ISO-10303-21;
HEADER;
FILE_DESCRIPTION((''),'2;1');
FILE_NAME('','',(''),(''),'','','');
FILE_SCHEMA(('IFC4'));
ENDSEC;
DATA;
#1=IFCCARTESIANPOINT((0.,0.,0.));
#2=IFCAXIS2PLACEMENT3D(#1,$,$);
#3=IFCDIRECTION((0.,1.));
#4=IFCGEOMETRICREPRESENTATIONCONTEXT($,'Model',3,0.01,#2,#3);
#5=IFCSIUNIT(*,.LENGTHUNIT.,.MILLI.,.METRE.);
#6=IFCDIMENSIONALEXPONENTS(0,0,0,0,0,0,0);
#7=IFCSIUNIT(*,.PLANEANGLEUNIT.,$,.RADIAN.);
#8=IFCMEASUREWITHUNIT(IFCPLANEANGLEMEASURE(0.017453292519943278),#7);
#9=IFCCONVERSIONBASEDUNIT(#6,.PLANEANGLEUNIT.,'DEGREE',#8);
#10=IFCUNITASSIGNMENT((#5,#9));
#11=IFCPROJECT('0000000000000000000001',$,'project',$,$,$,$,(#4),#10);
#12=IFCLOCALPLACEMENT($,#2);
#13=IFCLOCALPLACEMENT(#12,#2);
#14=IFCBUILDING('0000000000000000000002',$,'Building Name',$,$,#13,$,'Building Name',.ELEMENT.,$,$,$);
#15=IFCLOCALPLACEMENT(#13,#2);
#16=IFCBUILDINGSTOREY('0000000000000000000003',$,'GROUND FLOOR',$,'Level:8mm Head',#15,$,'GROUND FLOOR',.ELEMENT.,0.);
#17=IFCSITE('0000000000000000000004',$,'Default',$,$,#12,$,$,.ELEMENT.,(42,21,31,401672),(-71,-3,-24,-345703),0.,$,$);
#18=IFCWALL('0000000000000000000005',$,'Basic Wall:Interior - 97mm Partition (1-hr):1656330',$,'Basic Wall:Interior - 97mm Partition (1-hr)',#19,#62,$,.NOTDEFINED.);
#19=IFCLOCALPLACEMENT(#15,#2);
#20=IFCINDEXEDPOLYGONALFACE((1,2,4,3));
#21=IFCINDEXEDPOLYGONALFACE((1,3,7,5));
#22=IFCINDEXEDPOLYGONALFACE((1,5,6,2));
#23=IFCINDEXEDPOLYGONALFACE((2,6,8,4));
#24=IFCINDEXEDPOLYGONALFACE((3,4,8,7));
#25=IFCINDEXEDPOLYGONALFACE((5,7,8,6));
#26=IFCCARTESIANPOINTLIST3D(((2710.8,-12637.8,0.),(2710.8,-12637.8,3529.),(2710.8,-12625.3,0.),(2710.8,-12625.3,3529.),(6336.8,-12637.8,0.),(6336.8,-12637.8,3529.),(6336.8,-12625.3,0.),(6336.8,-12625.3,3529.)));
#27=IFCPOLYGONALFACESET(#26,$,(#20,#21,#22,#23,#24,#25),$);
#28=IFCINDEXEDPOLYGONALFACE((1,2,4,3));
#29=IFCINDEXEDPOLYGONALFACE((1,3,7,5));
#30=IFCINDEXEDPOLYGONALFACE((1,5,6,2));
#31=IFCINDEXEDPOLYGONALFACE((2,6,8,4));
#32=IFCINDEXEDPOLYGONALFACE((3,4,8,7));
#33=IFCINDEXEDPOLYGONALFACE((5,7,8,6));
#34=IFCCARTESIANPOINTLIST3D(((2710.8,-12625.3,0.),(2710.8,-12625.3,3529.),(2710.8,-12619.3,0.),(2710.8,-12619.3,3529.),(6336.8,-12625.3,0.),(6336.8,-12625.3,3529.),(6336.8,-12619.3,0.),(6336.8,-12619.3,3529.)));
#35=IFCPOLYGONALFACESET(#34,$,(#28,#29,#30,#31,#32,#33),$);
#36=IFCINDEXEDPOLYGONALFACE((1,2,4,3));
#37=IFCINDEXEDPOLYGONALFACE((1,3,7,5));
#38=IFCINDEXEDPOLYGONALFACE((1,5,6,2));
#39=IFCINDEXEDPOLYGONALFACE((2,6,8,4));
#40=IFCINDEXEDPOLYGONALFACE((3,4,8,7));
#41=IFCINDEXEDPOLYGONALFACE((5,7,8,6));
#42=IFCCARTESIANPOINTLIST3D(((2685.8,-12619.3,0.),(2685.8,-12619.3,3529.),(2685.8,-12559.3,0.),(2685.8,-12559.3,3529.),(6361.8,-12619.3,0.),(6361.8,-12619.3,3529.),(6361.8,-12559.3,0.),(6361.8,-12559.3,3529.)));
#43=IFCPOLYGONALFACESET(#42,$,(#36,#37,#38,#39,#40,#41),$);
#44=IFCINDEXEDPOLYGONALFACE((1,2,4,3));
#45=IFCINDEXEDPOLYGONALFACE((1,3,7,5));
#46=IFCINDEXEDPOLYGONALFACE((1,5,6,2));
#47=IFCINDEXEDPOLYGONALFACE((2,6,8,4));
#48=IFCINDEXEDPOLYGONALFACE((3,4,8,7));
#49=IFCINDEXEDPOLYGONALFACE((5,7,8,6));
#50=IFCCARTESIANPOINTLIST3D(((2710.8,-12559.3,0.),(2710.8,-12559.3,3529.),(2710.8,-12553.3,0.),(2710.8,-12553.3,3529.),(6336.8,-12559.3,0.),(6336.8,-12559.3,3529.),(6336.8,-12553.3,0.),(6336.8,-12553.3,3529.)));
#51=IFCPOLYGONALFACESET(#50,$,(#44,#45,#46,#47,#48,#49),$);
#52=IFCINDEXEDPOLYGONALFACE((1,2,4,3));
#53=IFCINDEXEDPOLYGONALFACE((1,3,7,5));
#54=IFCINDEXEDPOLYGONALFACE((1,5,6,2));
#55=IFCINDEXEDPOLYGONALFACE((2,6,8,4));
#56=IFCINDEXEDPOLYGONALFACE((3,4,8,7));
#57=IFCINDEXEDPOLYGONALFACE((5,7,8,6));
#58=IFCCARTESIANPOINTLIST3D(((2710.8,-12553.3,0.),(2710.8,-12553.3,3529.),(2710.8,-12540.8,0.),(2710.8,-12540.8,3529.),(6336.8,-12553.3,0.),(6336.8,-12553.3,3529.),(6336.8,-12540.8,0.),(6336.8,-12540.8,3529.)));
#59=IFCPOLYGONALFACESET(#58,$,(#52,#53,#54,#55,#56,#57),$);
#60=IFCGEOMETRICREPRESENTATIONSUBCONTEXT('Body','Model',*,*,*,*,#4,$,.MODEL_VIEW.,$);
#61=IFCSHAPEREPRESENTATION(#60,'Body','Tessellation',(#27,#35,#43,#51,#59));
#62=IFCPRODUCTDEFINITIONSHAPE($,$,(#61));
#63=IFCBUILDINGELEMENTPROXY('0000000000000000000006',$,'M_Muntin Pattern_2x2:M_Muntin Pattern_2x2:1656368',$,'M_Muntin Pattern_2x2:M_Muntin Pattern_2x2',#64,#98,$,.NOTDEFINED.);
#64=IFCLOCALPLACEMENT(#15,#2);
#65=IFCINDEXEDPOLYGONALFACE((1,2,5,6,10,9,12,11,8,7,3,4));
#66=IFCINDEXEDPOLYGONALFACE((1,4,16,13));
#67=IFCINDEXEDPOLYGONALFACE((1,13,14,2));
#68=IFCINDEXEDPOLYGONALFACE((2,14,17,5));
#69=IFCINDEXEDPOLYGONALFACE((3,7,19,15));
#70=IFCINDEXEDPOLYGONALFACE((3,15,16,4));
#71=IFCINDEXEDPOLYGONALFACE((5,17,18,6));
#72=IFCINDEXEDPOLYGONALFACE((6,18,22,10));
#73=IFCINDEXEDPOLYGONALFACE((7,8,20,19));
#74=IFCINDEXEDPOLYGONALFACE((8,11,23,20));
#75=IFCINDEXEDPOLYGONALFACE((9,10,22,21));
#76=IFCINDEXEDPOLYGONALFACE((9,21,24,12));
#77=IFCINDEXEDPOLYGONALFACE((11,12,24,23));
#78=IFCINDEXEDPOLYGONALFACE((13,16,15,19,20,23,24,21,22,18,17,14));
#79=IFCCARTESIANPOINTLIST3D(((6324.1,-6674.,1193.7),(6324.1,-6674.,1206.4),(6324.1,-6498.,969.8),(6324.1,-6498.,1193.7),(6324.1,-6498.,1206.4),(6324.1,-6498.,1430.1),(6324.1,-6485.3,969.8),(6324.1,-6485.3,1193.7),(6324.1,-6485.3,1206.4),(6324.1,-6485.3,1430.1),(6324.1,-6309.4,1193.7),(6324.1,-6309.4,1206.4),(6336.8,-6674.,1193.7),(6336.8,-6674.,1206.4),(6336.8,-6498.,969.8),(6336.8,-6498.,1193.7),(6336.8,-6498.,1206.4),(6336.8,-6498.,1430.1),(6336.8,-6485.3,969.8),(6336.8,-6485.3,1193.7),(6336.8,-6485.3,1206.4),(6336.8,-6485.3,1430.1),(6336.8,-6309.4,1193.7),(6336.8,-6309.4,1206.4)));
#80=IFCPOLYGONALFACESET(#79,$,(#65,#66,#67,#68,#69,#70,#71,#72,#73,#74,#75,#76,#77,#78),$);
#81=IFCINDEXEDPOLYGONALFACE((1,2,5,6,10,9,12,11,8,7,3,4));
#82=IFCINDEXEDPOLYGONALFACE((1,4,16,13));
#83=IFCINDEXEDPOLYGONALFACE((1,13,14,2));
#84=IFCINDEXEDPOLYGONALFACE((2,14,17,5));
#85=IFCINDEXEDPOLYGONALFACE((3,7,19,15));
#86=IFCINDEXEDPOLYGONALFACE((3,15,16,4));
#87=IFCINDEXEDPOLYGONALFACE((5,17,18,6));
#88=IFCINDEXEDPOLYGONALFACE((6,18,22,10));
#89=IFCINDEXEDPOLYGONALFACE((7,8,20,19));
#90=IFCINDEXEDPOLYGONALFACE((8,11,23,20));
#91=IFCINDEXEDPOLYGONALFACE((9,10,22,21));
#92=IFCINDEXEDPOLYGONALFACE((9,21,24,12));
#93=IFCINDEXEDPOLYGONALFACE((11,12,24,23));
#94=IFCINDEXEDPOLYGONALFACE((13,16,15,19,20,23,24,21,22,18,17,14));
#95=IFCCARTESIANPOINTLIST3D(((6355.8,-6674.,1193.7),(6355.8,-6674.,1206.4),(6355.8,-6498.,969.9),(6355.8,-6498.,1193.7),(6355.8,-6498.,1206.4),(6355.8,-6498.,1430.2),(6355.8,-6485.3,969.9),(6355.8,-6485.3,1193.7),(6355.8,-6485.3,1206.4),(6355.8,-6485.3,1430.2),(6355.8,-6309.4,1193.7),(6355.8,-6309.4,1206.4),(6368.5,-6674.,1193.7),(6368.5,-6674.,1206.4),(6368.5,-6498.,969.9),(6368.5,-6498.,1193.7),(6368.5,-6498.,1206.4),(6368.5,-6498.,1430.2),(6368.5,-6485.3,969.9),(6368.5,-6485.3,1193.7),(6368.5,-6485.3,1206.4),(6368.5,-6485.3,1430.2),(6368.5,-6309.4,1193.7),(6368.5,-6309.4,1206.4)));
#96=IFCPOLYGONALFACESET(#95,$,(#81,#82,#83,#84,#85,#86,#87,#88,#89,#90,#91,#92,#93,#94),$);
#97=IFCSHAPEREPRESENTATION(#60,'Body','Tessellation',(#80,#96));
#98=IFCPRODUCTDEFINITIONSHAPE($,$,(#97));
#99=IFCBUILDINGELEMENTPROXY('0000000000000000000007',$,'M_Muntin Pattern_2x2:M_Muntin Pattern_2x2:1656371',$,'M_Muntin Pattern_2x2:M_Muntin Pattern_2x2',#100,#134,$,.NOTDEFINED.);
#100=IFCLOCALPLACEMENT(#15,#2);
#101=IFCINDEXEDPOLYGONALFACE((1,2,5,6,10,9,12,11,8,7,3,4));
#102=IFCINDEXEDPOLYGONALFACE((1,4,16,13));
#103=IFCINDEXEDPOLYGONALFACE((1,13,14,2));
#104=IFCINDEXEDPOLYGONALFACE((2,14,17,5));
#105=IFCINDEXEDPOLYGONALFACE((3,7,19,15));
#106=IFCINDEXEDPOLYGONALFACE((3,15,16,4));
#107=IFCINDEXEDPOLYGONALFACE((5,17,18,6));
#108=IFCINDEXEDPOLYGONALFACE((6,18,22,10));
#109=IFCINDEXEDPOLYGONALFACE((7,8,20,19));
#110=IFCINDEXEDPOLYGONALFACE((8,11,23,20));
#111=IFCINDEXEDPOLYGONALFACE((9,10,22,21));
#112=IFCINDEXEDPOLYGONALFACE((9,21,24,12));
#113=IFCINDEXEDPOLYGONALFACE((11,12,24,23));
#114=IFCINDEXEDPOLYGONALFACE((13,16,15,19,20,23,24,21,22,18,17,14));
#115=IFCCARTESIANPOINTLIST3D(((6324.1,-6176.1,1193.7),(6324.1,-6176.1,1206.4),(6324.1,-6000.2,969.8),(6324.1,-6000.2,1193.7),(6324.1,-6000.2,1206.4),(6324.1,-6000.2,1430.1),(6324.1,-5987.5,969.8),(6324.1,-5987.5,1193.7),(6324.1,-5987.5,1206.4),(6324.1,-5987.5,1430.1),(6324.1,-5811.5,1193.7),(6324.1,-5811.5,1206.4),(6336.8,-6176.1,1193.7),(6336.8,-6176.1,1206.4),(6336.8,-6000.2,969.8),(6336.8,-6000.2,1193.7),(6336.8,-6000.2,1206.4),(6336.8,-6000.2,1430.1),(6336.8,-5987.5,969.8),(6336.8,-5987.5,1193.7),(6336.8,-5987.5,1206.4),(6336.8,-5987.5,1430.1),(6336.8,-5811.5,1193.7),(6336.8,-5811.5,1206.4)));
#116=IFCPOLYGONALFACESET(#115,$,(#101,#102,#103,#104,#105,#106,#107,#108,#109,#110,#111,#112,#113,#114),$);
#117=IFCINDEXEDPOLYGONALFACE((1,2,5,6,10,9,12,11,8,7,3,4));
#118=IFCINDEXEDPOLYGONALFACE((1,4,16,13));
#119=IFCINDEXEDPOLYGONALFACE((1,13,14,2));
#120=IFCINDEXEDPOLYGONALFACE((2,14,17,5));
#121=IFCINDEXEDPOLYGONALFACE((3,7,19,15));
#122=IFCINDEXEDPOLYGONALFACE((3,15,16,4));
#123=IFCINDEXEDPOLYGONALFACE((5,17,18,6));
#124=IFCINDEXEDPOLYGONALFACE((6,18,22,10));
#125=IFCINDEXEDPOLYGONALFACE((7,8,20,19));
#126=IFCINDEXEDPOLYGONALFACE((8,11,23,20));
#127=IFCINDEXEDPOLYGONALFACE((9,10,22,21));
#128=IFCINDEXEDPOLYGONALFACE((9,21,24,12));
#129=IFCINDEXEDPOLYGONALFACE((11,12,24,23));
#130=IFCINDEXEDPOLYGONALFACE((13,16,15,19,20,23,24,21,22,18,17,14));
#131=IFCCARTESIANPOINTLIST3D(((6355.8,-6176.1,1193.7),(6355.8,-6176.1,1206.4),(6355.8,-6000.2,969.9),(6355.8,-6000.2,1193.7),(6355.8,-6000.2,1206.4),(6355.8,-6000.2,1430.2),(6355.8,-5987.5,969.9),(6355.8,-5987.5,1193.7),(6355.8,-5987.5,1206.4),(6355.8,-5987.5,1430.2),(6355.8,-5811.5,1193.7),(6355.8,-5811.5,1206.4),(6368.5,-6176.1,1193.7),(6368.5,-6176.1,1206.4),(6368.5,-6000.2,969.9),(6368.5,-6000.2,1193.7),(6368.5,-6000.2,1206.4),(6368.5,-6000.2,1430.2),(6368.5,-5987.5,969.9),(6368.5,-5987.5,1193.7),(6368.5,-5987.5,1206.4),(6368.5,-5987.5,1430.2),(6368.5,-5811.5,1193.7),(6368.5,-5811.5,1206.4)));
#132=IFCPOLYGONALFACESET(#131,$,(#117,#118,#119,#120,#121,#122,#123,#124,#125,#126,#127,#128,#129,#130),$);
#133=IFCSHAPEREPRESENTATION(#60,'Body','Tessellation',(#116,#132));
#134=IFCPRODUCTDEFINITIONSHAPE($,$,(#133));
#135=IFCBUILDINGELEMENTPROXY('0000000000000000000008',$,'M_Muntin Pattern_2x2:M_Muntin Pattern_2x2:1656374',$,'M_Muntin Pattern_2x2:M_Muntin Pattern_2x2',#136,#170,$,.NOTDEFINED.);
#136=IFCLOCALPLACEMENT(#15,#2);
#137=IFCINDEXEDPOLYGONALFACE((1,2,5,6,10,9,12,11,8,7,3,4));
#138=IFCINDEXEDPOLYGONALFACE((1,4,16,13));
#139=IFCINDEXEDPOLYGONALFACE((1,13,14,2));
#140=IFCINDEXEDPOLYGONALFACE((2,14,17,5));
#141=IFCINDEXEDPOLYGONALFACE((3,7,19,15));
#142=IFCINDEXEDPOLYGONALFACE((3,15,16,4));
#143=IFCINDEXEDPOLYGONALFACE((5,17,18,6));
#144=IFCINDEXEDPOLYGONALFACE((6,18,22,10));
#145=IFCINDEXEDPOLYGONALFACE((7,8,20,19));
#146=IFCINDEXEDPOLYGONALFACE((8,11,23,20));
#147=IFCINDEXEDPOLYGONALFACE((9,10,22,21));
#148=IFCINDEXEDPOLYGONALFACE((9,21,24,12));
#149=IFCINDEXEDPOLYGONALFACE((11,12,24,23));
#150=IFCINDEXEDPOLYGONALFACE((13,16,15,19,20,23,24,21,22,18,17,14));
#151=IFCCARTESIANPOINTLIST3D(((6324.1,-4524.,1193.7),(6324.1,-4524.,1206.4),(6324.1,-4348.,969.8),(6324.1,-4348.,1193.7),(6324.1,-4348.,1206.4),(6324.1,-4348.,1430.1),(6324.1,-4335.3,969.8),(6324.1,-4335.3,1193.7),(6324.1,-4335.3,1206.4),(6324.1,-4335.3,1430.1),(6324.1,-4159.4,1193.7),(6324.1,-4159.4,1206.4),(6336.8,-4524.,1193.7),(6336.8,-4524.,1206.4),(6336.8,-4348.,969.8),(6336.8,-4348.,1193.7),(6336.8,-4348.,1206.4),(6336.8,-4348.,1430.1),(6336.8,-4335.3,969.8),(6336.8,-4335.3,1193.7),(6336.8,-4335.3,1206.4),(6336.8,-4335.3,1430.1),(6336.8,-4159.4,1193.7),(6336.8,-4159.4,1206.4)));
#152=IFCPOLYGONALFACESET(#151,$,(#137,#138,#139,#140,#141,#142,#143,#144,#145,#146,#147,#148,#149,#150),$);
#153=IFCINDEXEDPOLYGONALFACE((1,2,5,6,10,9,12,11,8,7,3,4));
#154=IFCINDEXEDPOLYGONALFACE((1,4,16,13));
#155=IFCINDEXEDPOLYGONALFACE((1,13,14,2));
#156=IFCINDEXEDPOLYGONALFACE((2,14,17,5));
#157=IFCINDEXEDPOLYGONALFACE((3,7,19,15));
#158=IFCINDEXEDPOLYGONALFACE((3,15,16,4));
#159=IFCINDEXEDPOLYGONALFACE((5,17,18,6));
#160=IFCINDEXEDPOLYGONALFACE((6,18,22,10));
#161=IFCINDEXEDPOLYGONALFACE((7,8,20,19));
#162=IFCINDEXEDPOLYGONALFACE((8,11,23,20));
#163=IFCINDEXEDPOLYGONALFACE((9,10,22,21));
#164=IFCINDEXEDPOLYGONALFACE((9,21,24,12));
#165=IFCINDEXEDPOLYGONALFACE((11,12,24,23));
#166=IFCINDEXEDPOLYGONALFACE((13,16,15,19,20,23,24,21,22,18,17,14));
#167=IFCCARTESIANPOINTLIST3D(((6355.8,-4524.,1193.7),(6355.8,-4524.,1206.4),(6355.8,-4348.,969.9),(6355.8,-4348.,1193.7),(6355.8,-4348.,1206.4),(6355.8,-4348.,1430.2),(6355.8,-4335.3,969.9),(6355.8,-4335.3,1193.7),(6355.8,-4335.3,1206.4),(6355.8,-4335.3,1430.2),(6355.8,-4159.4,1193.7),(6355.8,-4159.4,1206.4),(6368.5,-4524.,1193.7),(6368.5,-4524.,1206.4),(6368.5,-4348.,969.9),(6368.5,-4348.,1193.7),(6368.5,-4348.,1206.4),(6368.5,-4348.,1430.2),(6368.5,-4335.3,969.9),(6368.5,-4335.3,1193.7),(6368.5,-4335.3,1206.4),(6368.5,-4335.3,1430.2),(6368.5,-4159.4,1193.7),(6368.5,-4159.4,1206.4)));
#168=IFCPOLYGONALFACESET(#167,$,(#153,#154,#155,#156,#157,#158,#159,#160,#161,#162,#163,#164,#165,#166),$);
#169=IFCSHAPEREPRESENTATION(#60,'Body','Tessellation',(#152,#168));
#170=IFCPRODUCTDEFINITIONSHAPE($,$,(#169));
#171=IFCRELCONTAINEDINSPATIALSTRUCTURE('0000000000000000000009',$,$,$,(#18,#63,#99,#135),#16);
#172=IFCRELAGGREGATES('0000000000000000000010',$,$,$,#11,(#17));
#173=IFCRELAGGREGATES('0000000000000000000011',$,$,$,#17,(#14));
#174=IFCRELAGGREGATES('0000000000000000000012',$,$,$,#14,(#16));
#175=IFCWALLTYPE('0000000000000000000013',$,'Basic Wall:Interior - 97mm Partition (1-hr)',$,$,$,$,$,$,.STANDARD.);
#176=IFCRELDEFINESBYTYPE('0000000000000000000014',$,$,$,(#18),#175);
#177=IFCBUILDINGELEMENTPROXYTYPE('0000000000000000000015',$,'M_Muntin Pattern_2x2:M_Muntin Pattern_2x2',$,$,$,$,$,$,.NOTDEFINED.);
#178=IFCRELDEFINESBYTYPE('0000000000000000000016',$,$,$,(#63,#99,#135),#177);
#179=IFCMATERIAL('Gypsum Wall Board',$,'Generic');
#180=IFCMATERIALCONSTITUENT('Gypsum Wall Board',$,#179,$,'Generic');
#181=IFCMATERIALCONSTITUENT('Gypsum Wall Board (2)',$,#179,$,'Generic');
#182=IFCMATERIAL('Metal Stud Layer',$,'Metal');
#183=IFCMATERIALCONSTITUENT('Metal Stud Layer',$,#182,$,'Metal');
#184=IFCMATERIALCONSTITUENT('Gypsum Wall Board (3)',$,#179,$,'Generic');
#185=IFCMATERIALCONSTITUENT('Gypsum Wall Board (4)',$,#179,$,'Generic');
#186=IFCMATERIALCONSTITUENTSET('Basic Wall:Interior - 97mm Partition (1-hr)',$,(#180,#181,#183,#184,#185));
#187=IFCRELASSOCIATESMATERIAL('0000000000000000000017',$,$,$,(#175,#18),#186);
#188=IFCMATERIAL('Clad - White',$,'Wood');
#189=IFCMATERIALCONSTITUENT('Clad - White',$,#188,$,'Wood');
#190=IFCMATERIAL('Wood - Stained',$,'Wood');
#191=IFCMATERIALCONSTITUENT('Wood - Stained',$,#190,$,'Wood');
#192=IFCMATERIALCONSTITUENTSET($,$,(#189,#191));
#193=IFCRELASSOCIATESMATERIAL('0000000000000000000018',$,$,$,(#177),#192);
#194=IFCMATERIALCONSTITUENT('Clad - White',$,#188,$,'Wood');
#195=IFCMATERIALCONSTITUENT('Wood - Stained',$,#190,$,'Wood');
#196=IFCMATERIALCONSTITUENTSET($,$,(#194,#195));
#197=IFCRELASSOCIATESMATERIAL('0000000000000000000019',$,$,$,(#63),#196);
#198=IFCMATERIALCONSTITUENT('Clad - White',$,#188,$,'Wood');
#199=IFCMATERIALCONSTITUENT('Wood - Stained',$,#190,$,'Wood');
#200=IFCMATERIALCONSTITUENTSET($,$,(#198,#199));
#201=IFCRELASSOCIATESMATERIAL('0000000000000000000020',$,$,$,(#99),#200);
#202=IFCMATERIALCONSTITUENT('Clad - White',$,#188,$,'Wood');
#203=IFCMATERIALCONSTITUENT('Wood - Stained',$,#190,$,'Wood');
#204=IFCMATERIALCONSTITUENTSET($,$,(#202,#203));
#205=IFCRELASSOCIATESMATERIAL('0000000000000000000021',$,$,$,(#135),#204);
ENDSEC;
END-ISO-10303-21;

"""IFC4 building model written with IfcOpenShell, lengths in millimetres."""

from ifc_helpers import new_model, entity, si_unit, converted_unit, direction, frame, origin, place, context, subcontext, project, spatial, indexed_curve, outline, extrude, source, transform, mapped, material, constituent, constituent_set, type_object, type_shapes, element, save


model = new_model("IFC4")

# Units and contexts
model_context = context("Model", 3, precision=0.01, world=origin(), true_north=direction((0.0, 1.0)))
body_context = subcontext(model_context, "Body", "Model", "MODEL_VIEW")
ifc_project = project(units=[si_unit("LENGTHUNIT", "METRE", prefix="MILLI"), converted_unit("PLANEANGLEUNIT", "DEGREE", entity("IfcPlaneAngleMeasure", 0.017453292519943278), si_unit("PLANEANGLEUNIT", "RADIAN"), dimensions=[0, 0, 0, 0, 0, 0, 0])], contexts=[model_context])

# Site, building, storey
site_placement = place(None, origin())
site = spatial("IfcSite", under=ifc_project, at=site_placement, Name="Default", CompositionType="ELEMENT", RefLatitude=(42, 21, 31, 401672), RefLongitude=(-71, -3, -24, -345703), RefElevation=0.0)
building_placement = place(site_placement, origin())
building = spatial("IfcBuilding", under=site, at=building_placement, Name="Building Name", LongName="Building Name", CompositionType="ELEMENT")
storey_placement = place(building_placement, origin())
storey = spatial("IfcBuildingStorey", under=building, at=storey_placement, Name="GROUND FLOOR", ObjectType="Level:8mm Head", LongName="GROUND FLOOR", CompositionType="ELEMENT", Elevation=0.0)

# Shared definitions
ifc_material_1 = material(Name="Wood - Stained", Category="Wood")

# Wall
ifc_material_2 = material(Name="Gypsum Wall Board", Category="Generic")
ifc_constituent_1 = constituent(ifc_material_2, Name="Gypsum Wall Board", Category="Generic")
ifc_constituent_2 = constituent(ifc_material_2, Name="Gypsum Wall Board (2)", Category="Generic")
ifc_material_3 = material(Name="Metal Stud Layer", Category="Metal")
ifc_constituent_3 = constituent(ifc_material_3, Name="Metal Stud Layer", Category="Metal")
ifc_constituent_4 = constituent(ifc_material_2, Name="Gypsum Wall Board (3)", Category="Generic")
ifc_constituent_5 = constituent(ifc_material_2, Name="Gypsum Wall Board (4)", Category="Generic")
ifc_constituent_set_1 = constituent_set(constituents=[ifc_constituent_1, ifc_constituent_2, ifc_constituent_3, ifc_constituent_4, ifc_constituent_5], Name="Basic Wall:Interior - 97mm Partition (1-hr)")
wall_type_1 = type_object("IfcWallType", Name="Basic Wall:Interior - 97mm Partition (1-hr)", PredefinedType="STANDARD", material=ifc_constituent_set_1)
wall_1_placement = place(storey_placement, frame((6336.8, -12589.3, 0.0), z_axis=(0.0, 0.0, 1.0), x_axis=(-1.0, 0.0, 0.0)))
element("IfcWall", 1, at=wall_1_placement, inside=storey, type_object=wall_type_1, material=ifc_constituent_set_1, Name="Basic Wall:Interior - 97mm Partition (1-hr):1656330", ObjectType="Basic Wall:Interior - 97mm Partition (1-hr)", PredefinedType="NOTDEFINED", context=body_context, shape_type="SweptSolid", body=[
    extrude(outline(indexed_curve([(-6.2, -1764.5), (6.3, -1764.5), (6.2, 1764.5), (-6.2, 1764.5), (-6.2, -1764.5)], self_intersect=False)), frame((3626.0, 42.2, 1764.5), z_axis=(-1.0, 0.0, 0.0), x_axis=(0.0, -1.0, 0.0)), (0.0, 0.0, 1.0), 3626.0),
    extrude(outline(indexed_curve([(-1764.5, -3.0), (1764.5, -3.0), (1764.5, 3.0), (-1764.5, 3.0), (-1764.5, -3.0)], self_intersect=False)), frame((3626.0, 33.0, 1764.5), z_axis=(-1.0, 0.0, 0.0), x_axis=(0.0, 0.0, 1.0)), (0.0, 0.0, 1.0), 3626.0),
    extrude(outline(indexed_curve([(-1764.5, -30.0), (1764.5, -30.0), (1764.5, 30.0), (-1764.5, 30.0), (-1764.5, -30.0)], self_intersect=False)), frame((3651.0, 0.0, 1764.5), z_axis=(-1.0, 0.0, 0.0), x_axis=(0.0, 0.0, 1.0)), (0.0, 0.0, 1.0), 3676.0),
    extrude(outline(indexed_curve([(-1764.5, -3.0), (1764.5, -3.0), (1764.5, 3.0), (-1764.5, 3.0), (-1764.5, -3.0)], self_intersect=False)), frame((3626.0, -33.0, 1764.5), z_axis=(-1.0, 0.0, 0.0), x_axis=(0.0, 0.0, 1.0)), (0.0, 0.0, 1.0), 3626.0),
    extrude(outline(indexed_curve([(-6.3, -1764.5), (6.2, -1764.5), (6.2, 1764.5), (-6.3, 1764.5), (-6.3, -1764.5)], self_intersect=False)), frame((3626.0, -42.3, 1764.5), z_axis=(-1.0, 0.0, 0.0), x_axis=(0.0, 1.0, 0.0)), (0.0, 0.0, 1.0), 3626.0),
])

# Building element proxies
ifc_material_4 = material(Name="Clad - White", Category="Wood")
ifc_constituent_6 = constituent(ifc_material_4, Name="Clad - White", Category="Wood")
ifc_constituent_7 = constituent(ifc_material_1, Name="Wood - Stained", Category="Wood")
ifc_constituent_set_2 = constituent_set(constituents=[ifc_constituent_6, ifc_constituent_7])
ifc_constituent_8 = constituent(ifc_material_4, Name="Clad - White", Category="Wood")
ifc_constituent_9 = constituent(ifc_material_1, Name="Wood - Stained", Category="Wood")
ifc_constituent_set_3 = constituent_set(constituents=[ifc_constituent_8, ifc_constituent_9])
building_element_proxy_type_1 = type_object("IfcBuildingElementProxyType", Name="M_Muntin Pattern_2x2:M_Muntin Pattern_2x2", PredefinedType="NOTDEFINED", material=ifc_constituent_set_3)
shared_shape_1 = source(origin(), body_context, "Body", "SweptSolid", [
    extrude(outline(indexed_curve([(6.4, -6.4), (230.1, -6.4), (230.1, 6.3), (6.4, 6.3), (6.4, 182.3), (-6.3, 182.3), (-6.3, 6.3), (-230.2, 6.3), (-230.2, -6.4), (-6.3, -6.4), (-6.3, -182.3), (6.4, -182.3), (6.4, -6.4)], self_intersect=False)), frame((0.0, 9.5, 230.1), z_axis=(0.0, 1.0, 0.0), x_axis=(0.0, 0.0, 1.0)), (0.0, 0.0, 1.0), 12.7),
    extrude(outline(indexed_curve([(6.4, -6.4), (230.2, -6.4), (230.2, 6.3), (6.4, 6.3), (6.4, 182.3), (-6.3, 182.3), (-6.3, 6.3), (-230.2, 6.3), (-230.2, -6.4), (-6.3, -6.4), (-6.3, -182.3), (6.4, -182.3), (6.4, -6.4)], self_intersect=False)), frame((0.0, -22.2, 230.2), z_axis=(0.0, 1.0, 0.0), x_axis=(0.0, 0.0, 1.0)), (0.0, 0.0, 1.0), 12.7),
])
type_shapes(building_element_proxy_type_1, [shared_shape_1])
proxy_1_placement = place(storey_placement, frame((6346.3, -6491.7, 969.9), z_axis=(0.0, 0.0, 1.0), x_axis=(0.0, 1.0, 0.0)))
element("IfcBuildingElementProxy", 2, at=proxy_1_placement, inside=storey, type_object=building_element_proxy_type_1, material=ifc_constituent_set_2, Name="M_Muntin Pattern_2x2:M_Muntin Pattern_2x2:1656368", ObjectType="M_Muntin Pattern_2x2:M_Muntin Pattern_2x2", PredefinedType="NOTDEFINED", context=body_context, shape_type="MappedRepresentation", body=[
    mapped(shared_shape_1, transform((0.0, 0.0, 0.0), scale=1.0)),
])
ifc_constituent_10 = constituent(ifc_material_4, Name="Clad - White", Category="Wood")
ifc_constituent_11 = constituent(ifc_material_1, Name="Wood - Stained", Category="Wood")
ifc_constituent_set_4 = constituent_set(constituents=[ifc_constituent_10, ifc_constituent_11])
proxy_2_placement = place(storey_placement, frame((6346.3, -5993.8, 969.9), z_axis=(0.0, 0.0, 1.0), x_axis=(0.0, 1.0, 0.0)))
element("IfcBuildingElementProxy", 3, at=proxy_2_placement, inside=storey, type_object=building_element_proxy_type_1, material=ifc_constituent_set_4, Name="M_Muntin Pattern_2x2:M_Muntin Pattern_2x2:1656371", ObjectType="M_Muntin Pattern_2x2:M_Muntin Pattern_2x2", PredefinedType="NOTDEFINED", context=body_context, shape_type="MappedRepresentation", body=[
    mapped(shared_shape_1, transform((0.0, 0.0, 0.0), scale=1.0)),
])
ifc_constituent_12 = constituent(ifc_material_4, Name="Clad - White", Category="Wood")
ifc_constituent_13 = constituent(ifc_material_1, Name="Wood - Stained", Category="Wood")
ifc_constituent_set_5 = constituent_set(constituents=[ifc_constituent_12, ifc_constituent_13])
proxy_3_placement = place(storey_placement, frame((6346.3, -4341.7, 969.9), z_axis=(0.0, 0.0, 1.0), x_axis=(0.0, 1.0, 0.0)))
element("IfcBuildingElementProxy", 4, at=proxy_3_placement, inside=storey, type_object=building_element_proxy_type_1, material=ifc_constituent_set_5, Name="M_Muntin Pattern_2x2:M_Muntin Pattern_2x2:1656374", ObjectType="M_Muntin Pattern_2x2:M_Muntin Pattern_2x2", PredefinedType="NOTDEFINED", context=body_context, shape_type="MappedRepresentation", body=[
    mapped(shared_shape_1, transform((0.0, 0.0, 0.0), scale=1.0)),
])

save(model, "model.ifc")
